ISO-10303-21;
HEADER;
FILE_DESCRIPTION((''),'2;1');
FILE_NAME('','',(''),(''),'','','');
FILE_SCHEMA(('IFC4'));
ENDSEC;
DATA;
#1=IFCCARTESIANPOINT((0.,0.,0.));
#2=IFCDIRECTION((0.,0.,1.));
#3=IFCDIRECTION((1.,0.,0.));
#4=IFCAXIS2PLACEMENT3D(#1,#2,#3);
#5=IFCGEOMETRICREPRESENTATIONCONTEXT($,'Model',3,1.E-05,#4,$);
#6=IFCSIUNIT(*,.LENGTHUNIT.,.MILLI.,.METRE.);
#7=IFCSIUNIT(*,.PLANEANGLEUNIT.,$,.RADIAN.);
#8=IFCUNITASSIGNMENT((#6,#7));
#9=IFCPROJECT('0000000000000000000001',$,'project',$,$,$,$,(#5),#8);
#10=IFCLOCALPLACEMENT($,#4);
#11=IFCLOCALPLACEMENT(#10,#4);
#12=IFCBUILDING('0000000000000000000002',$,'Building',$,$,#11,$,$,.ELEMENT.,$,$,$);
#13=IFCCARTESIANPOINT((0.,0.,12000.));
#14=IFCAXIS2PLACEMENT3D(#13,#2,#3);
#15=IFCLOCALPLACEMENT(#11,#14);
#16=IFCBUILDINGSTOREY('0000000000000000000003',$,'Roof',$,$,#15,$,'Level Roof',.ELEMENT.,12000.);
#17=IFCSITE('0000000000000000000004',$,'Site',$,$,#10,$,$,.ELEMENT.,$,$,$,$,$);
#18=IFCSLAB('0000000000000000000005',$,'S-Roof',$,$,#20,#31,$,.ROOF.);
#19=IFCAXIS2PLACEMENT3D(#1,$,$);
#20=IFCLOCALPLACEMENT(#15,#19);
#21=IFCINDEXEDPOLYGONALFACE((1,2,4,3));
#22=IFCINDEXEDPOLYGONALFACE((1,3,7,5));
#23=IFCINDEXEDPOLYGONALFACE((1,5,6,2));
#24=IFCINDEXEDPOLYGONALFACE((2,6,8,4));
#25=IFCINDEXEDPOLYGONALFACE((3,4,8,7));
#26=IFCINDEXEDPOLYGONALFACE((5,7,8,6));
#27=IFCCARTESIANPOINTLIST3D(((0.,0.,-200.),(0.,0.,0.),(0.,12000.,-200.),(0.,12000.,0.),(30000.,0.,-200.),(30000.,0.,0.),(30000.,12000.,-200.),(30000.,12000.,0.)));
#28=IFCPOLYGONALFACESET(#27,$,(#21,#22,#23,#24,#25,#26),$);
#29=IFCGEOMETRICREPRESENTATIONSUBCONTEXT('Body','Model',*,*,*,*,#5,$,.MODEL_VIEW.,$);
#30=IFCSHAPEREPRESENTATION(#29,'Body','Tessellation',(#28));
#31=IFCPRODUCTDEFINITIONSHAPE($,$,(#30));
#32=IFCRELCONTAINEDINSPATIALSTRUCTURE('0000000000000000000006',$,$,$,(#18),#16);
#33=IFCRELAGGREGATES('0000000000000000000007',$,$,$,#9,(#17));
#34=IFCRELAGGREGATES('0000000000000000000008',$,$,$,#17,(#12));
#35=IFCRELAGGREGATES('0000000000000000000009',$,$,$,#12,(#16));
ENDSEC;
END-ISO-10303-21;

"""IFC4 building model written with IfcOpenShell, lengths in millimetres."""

from ifc_helpers import new_model, si_unit, frame, origin_with_axes, origin_2d, place, context, subcontext, project, spatial, rectangle, extrude, element, save


model = new_model("IFC4")

# Units and contexts
model_context = context("Model", 3, precision=1e-05, world=origin_with_axes())
body_context = subcontext(model_context, "Body", "Model", "MODEL_VIEW")
ifc_project = project(units=[si_unit("LENGTHUNIT", "METRE", prefix="MILLI"), si_unit("PLANEANGLEUNIT", "RADIAN")], contexts=[model_context])

# Site, building, storey
site_placement = place(None, origin_with_axes())
site = spatial("IfcSite", under=ifc_project, at=site_placement, Name="Site", CompositionType="ELEMENT")
building_placement = place(site_placement, origin_with_axes())
building = spatial("IfcBuilding", under=site, at=building_placement, Name="Building", CompositionType="ELEMENT")
storey_placement = place(building_placement, frame((0.0, 0.0, 12000.0), z_axis=(0.0, 0.0, 1.0), x_axis=(1.0, 0.0, 0.0)))
storey = spatial("IfcBuildingStorey", under=building, at=storey_placement, Name="Roof", LongName="Level Roof", CompositionType="ELEMENT", Elevation=12000.0)

# Slab
slab_placement = place(storey_placement, frame((15000.0, 6000.0, -200.0), z_axis=(0.0, 0.0, 1.0), x_axis=(1.0, 0.0, 0.0)))
element("IfcSlab", 1, at=slab_placement, inside=storey, Name="S-Roof", PredefinedType="ROOF", context=body_context, shape_type="SweptSolid", body=[
    extrude(rectangle(XDim=30000.0, YDim=12000.0, at=origin_2d()), origin_with_axes(), (0.0, 0.0, 1.0), 200.0),
])

save(model, "model.ifc")
